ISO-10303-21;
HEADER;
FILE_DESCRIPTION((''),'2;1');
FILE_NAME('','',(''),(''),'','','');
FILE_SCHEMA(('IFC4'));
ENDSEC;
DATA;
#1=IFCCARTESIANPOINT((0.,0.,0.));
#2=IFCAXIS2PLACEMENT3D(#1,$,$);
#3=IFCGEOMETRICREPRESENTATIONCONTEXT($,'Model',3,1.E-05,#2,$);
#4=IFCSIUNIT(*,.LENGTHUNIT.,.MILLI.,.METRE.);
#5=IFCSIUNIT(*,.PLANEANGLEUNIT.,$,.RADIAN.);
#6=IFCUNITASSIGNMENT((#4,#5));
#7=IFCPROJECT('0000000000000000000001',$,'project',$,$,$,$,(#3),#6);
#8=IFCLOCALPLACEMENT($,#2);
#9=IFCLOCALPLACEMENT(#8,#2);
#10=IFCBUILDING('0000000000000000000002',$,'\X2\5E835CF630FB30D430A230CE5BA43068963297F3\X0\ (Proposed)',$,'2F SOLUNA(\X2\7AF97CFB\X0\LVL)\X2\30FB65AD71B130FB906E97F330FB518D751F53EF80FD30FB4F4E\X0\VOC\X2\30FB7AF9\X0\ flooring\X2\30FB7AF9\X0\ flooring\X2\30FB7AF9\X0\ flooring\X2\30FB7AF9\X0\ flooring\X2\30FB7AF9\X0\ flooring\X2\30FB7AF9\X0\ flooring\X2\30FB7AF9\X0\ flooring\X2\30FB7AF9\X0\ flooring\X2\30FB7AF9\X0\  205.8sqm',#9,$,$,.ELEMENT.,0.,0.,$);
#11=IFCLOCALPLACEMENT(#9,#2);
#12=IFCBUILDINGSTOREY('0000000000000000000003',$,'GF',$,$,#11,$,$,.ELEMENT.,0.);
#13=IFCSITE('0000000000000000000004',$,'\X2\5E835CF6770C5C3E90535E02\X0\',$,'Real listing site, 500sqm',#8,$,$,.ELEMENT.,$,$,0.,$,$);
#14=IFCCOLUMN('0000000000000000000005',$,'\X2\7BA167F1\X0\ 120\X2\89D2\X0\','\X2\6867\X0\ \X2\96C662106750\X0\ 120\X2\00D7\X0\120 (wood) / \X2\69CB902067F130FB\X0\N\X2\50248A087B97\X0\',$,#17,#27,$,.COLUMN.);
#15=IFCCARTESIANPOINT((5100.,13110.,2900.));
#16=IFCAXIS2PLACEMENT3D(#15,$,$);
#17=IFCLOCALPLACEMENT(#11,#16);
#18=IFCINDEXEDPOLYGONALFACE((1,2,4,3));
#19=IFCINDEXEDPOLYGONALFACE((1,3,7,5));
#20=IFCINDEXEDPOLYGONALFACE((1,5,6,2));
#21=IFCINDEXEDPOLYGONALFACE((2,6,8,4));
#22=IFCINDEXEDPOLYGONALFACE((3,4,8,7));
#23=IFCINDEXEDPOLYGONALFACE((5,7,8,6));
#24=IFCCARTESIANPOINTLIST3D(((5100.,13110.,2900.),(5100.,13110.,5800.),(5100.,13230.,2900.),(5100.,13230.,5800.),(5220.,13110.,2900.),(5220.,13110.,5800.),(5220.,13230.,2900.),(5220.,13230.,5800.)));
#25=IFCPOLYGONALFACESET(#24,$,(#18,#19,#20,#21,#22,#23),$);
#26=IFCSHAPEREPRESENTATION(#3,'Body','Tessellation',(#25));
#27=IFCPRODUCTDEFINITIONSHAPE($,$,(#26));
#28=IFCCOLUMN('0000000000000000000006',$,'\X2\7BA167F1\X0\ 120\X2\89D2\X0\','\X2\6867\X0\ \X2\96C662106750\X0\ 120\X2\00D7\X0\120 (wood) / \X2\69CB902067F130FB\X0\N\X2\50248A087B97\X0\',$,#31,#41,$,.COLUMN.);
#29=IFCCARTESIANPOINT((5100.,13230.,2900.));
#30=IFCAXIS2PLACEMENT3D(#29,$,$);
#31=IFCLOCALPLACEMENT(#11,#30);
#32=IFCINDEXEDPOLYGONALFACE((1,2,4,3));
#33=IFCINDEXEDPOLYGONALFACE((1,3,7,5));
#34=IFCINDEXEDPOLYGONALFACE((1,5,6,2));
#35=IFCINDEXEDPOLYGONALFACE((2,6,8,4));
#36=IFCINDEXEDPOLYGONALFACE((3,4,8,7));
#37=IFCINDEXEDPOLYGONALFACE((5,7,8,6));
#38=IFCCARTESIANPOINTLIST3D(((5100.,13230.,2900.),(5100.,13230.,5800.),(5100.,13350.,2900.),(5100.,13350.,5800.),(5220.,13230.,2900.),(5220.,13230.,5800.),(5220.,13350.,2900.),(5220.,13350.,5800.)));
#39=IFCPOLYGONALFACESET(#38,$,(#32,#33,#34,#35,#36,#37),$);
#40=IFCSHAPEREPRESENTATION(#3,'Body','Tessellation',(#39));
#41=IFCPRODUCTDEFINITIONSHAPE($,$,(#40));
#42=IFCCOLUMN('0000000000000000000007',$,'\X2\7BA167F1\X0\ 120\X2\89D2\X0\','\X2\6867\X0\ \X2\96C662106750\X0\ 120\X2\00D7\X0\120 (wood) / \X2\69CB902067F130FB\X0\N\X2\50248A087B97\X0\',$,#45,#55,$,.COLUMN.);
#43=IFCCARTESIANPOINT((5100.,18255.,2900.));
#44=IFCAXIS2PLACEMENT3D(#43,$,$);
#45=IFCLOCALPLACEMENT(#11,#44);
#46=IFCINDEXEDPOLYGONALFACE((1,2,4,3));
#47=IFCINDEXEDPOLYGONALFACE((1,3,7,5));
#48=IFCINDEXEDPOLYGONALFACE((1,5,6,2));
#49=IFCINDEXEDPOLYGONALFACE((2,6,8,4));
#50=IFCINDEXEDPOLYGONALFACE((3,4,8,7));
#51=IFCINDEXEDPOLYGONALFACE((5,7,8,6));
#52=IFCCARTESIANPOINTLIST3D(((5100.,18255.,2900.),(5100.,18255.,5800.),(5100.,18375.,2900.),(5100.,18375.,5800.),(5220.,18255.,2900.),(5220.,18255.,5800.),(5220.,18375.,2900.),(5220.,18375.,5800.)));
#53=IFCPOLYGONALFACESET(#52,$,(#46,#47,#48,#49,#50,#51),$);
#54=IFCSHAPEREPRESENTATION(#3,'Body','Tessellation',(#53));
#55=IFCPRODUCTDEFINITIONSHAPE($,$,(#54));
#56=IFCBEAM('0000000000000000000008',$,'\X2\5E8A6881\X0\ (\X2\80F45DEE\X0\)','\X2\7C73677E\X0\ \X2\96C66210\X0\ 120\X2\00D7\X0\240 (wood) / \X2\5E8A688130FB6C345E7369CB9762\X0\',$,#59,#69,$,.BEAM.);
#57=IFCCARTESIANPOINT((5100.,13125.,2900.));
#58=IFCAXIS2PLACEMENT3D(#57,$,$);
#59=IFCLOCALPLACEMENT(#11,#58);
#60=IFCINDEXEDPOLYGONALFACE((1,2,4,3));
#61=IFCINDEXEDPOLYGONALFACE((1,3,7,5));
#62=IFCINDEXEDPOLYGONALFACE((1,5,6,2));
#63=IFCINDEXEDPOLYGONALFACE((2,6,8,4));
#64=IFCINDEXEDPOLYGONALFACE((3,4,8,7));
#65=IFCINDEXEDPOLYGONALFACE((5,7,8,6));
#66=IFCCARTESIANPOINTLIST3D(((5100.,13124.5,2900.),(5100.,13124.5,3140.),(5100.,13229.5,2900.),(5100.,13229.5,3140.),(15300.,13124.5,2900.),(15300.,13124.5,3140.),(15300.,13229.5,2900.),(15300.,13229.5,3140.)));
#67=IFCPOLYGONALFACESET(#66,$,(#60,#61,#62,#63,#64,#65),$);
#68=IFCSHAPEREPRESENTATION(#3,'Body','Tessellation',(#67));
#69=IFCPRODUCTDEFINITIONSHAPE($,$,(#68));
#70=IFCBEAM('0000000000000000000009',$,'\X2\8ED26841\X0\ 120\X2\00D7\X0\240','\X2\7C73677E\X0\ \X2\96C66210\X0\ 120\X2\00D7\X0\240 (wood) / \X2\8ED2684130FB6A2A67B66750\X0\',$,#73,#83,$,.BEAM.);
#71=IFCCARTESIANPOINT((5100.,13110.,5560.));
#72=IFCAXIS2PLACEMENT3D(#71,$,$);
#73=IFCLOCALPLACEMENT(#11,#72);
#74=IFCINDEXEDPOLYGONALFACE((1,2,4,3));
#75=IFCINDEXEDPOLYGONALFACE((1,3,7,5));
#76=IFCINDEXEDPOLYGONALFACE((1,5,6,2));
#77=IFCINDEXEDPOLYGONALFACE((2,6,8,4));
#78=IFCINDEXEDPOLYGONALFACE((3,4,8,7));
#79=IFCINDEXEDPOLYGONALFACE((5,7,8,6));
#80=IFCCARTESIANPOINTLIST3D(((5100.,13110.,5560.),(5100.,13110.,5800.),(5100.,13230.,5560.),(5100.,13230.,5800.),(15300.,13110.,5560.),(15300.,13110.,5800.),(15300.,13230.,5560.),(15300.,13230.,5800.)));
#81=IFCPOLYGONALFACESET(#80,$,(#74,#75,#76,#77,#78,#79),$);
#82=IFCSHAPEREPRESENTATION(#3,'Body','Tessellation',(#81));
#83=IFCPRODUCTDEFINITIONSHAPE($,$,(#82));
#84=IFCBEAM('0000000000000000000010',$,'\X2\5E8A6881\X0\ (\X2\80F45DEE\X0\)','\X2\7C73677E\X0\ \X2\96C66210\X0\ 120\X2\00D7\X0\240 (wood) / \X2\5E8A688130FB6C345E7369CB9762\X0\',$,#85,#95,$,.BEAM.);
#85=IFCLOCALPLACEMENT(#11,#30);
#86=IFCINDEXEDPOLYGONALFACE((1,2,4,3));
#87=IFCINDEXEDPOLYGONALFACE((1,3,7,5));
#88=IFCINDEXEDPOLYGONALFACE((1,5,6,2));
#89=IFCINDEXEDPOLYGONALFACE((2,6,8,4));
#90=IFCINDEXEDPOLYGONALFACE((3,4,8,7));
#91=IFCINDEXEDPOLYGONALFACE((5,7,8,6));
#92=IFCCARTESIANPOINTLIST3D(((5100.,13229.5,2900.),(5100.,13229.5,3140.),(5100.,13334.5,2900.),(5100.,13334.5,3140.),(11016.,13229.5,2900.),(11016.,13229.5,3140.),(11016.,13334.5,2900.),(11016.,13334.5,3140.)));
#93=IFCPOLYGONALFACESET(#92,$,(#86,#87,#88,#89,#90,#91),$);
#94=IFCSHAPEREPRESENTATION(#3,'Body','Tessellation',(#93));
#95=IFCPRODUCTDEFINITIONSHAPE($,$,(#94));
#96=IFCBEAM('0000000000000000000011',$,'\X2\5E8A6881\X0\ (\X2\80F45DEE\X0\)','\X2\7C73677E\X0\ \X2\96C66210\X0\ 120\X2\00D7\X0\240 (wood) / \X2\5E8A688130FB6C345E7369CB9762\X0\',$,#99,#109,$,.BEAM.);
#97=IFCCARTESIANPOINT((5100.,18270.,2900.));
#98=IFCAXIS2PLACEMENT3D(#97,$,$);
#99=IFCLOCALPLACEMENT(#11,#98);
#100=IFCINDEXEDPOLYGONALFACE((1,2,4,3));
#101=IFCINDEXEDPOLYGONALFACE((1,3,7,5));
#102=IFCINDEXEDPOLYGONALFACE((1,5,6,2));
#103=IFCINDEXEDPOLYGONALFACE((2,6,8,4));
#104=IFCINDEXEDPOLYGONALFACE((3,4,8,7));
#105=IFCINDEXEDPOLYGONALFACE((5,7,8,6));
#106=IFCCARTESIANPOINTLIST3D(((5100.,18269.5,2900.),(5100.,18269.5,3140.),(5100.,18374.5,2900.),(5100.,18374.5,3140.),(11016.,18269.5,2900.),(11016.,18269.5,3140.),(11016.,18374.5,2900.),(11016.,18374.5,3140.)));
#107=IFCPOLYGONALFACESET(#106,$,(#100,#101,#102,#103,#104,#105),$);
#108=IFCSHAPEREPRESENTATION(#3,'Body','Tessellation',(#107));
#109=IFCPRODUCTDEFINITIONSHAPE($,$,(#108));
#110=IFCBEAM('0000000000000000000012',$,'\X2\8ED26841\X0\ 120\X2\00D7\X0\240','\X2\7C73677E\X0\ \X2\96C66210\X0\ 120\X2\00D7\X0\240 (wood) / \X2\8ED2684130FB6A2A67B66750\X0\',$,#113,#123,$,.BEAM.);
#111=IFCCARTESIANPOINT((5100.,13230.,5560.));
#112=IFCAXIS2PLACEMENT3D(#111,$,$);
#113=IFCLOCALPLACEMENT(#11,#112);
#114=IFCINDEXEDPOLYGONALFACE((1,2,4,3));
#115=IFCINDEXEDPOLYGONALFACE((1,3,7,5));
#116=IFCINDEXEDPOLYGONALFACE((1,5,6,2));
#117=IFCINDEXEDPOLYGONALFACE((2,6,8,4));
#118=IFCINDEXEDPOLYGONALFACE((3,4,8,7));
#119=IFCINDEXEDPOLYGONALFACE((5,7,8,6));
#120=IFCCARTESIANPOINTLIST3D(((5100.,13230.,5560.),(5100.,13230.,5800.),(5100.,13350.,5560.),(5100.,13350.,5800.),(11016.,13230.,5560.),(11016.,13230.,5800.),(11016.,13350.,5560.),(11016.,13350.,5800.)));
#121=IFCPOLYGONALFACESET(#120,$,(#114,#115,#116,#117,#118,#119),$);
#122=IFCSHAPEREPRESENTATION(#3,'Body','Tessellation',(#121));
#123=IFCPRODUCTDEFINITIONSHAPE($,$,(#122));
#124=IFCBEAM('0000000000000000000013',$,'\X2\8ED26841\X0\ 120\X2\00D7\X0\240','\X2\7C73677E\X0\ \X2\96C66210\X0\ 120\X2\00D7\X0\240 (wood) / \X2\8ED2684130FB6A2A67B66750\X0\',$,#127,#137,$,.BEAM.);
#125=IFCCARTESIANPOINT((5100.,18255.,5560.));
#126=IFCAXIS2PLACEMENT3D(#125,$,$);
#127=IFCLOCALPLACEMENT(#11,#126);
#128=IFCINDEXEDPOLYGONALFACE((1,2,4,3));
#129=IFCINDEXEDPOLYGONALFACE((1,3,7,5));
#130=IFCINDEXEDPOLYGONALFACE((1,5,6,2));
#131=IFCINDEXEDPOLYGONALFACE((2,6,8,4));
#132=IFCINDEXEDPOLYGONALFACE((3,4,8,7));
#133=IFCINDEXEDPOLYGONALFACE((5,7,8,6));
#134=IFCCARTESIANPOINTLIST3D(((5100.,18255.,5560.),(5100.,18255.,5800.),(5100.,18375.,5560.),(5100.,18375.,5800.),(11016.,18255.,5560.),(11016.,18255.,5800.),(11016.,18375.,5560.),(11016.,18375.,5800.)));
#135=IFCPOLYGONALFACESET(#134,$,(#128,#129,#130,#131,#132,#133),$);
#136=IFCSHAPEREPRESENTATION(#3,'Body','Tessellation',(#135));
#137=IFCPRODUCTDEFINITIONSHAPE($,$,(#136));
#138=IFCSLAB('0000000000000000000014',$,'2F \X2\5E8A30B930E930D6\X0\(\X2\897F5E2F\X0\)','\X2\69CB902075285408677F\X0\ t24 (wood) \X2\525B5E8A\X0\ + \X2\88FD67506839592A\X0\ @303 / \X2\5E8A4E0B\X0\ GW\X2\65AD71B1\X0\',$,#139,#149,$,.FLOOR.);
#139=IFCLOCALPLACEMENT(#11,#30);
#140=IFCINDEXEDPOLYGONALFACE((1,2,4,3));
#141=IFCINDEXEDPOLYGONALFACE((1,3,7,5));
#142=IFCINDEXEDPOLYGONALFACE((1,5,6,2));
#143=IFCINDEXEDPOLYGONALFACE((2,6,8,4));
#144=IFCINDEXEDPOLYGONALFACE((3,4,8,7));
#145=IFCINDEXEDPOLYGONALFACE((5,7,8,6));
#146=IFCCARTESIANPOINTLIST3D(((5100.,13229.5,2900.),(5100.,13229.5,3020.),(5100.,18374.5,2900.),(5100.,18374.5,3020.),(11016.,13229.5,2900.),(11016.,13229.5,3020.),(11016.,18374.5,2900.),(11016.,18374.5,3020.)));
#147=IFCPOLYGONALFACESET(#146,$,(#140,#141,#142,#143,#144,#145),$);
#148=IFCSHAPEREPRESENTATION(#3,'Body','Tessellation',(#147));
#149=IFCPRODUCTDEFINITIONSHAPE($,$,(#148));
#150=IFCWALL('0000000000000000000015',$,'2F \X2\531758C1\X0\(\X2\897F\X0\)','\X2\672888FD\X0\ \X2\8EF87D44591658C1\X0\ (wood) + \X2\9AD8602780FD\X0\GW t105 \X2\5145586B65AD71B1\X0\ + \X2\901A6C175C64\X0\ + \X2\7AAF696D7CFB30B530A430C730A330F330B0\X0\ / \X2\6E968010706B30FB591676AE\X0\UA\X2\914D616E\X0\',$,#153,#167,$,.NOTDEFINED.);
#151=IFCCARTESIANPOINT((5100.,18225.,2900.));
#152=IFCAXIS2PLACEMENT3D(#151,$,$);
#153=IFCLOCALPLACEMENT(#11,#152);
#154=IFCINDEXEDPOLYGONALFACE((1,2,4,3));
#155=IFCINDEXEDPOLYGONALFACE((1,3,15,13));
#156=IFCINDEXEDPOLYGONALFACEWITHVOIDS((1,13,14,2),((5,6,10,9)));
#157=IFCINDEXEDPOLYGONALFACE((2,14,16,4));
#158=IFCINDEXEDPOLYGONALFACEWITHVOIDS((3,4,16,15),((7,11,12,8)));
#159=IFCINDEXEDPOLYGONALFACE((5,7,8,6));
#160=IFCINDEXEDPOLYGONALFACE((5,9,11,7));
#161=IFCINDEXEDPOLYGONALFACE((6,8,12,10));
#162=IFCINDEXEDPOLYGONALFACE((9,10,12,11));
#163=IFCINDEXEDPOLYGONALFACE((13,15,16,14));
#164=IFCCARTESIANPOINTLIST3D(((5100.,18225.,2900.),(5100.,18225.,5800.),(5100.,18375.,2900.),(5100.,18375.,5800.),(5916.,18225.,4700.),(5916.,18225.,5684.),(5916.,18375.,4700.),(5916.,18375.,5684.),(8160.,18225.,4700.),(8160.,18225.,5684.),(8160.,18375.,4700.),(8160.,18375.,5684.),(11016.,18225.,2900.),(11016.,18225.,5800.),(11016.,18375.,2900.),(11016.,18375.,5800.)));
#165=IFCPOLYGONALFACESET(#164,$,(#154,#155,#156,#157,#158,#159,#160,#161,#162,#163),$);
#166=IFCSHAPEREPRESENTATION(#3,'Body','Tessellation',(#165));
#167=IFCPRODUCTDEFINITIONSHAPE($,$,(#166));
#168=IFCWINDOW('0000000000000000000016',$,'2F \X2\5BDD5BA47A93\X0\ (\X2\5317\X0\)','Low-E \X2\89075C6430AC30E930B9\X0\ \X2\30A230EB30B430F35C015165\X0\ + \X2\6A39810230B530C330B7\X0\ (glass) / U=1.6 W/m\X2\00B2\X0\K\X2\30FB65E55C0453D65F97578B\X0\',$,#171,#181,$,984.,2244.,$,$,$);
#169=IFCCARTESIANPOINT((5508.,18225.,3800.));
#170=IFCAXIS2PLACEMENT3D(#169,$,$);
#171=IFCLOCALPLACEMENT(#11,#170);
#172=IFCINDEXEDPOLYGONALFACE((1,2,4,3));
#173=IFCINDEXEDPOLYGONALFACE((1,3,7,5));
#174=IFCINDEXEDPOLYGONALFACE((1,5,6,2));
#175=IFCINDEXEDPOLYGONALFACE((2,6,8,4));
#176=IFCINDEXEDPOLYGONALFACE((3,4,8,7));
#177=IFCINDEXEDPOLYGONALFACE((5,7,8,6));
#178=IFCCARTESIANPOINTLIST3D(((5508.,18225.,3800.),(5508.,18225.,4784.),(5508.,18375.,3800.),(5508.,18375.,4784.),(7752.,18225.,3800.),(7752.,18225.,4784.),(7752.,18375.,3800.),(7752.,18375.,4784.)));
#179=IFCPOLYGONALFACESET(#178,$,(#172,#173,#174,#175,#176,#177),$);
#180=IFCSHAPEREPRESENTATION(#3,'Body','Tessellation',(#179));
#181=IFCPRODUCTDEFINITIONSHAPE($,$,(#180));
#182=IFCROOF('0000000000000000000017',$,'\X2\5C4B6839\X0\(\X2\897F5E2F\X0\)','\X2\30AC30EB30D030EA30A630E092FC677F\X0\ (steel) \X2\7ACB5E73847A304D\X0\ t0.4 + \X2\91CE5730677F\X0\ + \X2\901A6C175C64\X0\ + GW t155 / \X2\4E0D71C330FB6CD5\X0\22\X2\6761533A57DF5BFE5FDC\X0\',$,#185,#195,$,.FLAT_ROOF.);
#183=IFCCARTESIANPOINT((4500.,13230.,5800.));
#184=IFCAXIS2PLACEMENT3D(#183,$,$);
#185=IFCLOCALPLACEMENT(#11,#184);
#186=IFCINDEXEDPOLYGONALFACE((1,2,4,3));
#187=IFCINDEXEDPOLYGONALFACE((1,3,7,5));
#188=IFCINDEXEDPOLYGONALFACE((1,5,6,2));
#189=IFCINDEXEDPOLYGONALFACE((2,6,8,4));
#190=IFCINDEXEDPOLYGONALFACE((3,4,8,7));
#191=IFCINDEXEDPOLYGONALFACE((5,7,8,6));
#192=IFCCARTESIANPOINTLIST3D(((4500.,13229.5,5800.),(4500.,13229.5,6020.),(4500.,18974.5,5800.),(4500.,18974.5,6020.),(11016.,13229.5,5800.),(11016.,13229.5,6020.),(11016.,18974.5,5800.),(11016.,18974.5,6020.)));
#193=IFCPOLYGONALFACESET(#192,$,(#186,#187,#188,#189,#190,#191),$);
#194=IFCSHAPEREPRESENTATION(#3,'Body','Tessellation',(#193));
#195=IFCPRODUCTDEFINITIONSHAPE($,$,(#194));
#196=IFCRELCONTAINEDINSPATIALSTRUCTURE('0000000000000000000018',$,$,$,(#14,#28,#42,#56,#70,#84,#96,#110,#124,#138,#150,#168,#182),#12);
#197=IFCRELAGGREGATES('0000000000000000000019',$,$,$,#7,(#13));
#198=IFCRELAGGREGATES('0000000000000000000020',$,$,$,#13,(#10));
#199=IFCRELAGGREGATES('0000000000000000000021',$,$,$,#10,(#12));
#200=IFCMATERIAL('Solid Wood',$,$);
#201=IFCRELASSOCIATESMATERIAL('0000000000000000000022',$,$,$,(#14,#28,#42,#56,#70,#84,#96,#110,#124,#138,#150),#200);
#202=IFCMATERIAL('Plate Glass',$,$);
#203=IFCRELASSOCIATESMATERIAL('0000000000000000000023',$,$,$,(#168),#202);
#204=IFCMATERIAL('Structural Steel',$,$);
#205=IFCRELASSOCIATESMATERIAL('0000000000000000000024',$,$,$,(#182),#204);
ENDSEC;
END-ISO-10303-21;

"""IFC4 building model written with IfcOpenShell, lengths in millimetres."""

from ifc_helpers import new_model, si_unit, frame, frame_2d, origin, place, context, project, spatial, rectangle, extrude, material, element, fill, save


model = new_model("IFC4")

# Units and contexts
model_context = context("Model", 3, precision=1e-05, world=origin())
ifc_project = project(units=[si_unit("LENGTHUNIT", "METRE", prefix="MILLI"), si_unit("PLANEANGLEUNIT", "RADIAN")], contexts=[model_context])

# Site, building, storey
site_placement = place(None, origin())
site = spatial("IfcSite", under=ifc_project, at=site_placement, Name="広島県尾道市", ObjectType="Real listing site, 500sqm", CompositionType="ELEMENT", RefElevation=0.0)
building_placement = place(site_placement, origin())
building = spatial("IfcBuilding", under=site, at=building_placement, Name="広島・ピアノ室と防音 (Proposed)", ObjectType="2F SOLUNA(竹系LVL)・断熱・遮音・再生可能・低VOC・竹 flooring・竹 flooring・竹 flooring・竹 flooring・竹 flooring・竹 flooring・竹 flooring・竹 flooring・竹  205.8sqm", CompositionType="ELEMENT", ElevationOfRefHeight=0.0, ElevationOfTerrain=0.0)
storey_placement = place(building_placement, origin())
storey = spatial("IfcBuildingStorey", under=building, at=storey_placement, Name="GF", CompositionType="ELEMENT", Elevation=0.0)

# Columns
ifc_material_1 = material(Name="Solid Wood")
column_1_placement = place(storey_placement, frame((5100.0, 13110.0, 2900.0)))
element("IfcColumn", 1, at=column_1_placement, inside=storey, material=ifc_material_1, Name="管柱 120角", Description="桧 集成材 120×120 (wood) / 構造柱・N値計算", PredefinedType="COLUMN", context=model_context, shape_type="SweptSolid", body=[
    extrude(rectangle(XDim=120.0, YDim=120.0, at=frame_2d((60.0, 60.0))), frame((5100.0, 13110.0, 2900.0)), (0.0, 0.0, 1.0), 2900.0),
])
column_2_placement = place(storey_placement, frame((5100.0, 13230.0, 2900.0)))
element("IfcColumn", 2, at=column_2_placement, inside=storey, material=ifc_material_1, Name="管柱 120角", Description="桧 集成材 120×120 (wood) / 構造柱・N値計算", PredefinedType="COLUMN", context=model_context, shape_type="SweptSolid", body=[
    extrude(rectangle(XDim=120.0, YDim=120.0, at=frame_2d((60.0, 60.0))), frame((5100.0, 13230.0, 2900.0)), (0.0, 0.0, 1.0), 2900.0),
])
column_3_placement = place(storey_placement, frame((5100.0, 18255.0, 2900.0)))
element("IfcColumn", 3, at=column_3_placement, inside=storey, material=ifc_material_1, Name="管柱 120角", Description="桧 集成材 120×120 (wood) / 構造柱・N値計算", PredefinedType="COLUMN", context=model_context, shape_type="SweptSolid", body=[
    extrude(rectangle(XDim=120.0, YDim=120.0, at=frame_2d((60.0, 60.0))), frame((5100.0, 18255.0, 2900.0)), (0.0, 0.0, 1.0), 2900.0),
])

# Beams
beam_1_placement = place(storey_placement, frame((5100.0, 13125.0, 2900.0)))
element("IfcBeam", 4, at=beam_1_placement, inside=storey, material=ifc_material_1, Name="床梁 (胴差)", Description="米松 集成 120×240 (wood) / 床梁・水平構面", PredefinedType="BEAM", context=model_context, shape_type="SweptSolid", body=[
    extrude(rectangle(XDim=10200.0, YDim=105.0, at=frame_2d((5100.0, 52.0))), frame((5100.0, 13125.0, 2900.0)), (0.0, 0.0, 1.0), 240.0),
])
beam_2_placement = place(storey_placement, frame((5100.0, 13110.0, 5560.0)))
element("IfcBeam", 5, at=beam_2_placement, inside=storey, material=ifc_material_1, Name="軒桁 120×240", Description="米松 集成 120×240 (wood) / 軒桁・横架材", PredefinedType="BEAM", context=model_context, shape_type="SweptSolid", body=[
    extrude(rectangle(XDim=10200.0, YDim=120.0, at=frame_2d((5100.0, 60.0))), frame((5100.0, 13110.0, 5560.0)), (0.0, 0.0, 1.0), 240.0),
])
beam_3_placement = place(storey_placement, frame((5100.0, 13230.0, 2900.0)))
element("IfcBeam", 6, at=beam_3_placement, inside=storey, material=ifc_material_1, Name="床梁 (胴差)", Description="米松 集成 120×240 (wood) / 床梁・水平構面", PredefinedType="BEAM", context=model_context, shape_type="SweptSolid", body=[
    extrude(rectangle(XDim=5916.0, YDim=105.0, at=frame_2d((2958.0, 52.0))), frame((5100.0, 13230.0, 2900.0)), (0.0, 0.0, 1.0), 240.0),
])
beam_4_placement = place(storey_placement, frame((5100.0, 18270.0, 2900.0)))
element("IfcBeam", 7, at=beam_4_placement, inside=storey, material=ifc_material_1, Name="床梁 (胴差)", Description="米松 集成 120×240 (wood) / 床梁・水平構面", PredefinedType="BEAM", context=model_context, shape_type="SweptSolid", body=[
    extrude(rectangle(XDim=5916.0, YDim=105.0, at=frame_2d((2958.0, 52.0))), frame((5100.0, 18270.0, 2900.0)), (0.0, 0.0, 1.0), 240.0),
])
beam_5_placement = place(storey_placement, frame((5100.0, 13230.0, 5560.0)))
element("IfcBeam", 8, at=beam_5_placement, inside=storey, material=ifc_material_1, Name="軒桁 120×240", Description="米松 集成 120×240 (wood) / 軒桁・横架材", PredefinedType="BEAM", context=model_context, shape_type="SweptSolid", body=[
    extrude(rectangle(XDim=5916.0, YDim=120.0, at=frame_2d((2958.0, 60.0))), frame((5100.0, 13230.0, 5560.0)), (0.0, 0.0, 1.0), 240.0),
])
beam_6_placement = place(storey_placement, frame((5100.0, 18255.0, 5560.0)))
element("IfcBeam", 9, at=beam_6_placement, inside=storey, material=ifc_material_1, Name="軒桁 120×240", Description="米松 集成 120×240 (wood) / 軒桁・横架材", PredefinedType="BEAM", context=model_context, shape_type="SweptSolid", body=[
    extrude(rectangle(XDim=5916.0, YDim=120.0, at=frame_2d((2958.0, 60.0))), frame((5100.0, 18255.0, 5560.0)), (0.0, 0.0, 1.0), 240.0),
])

# Slab
slab_placement = place(storey_placement, frame((5100.0, 13230.0, 2900.0)))
element("IfcSlab", 10, at=slab_placement, inside=storey, material=ifc_material_1, Name="2F 床スラブ(西帯)", Description="構造用合板 t24 (wood) 剛床 + 製材根太 @303 / 床下 GW断熱", PredefinedType="FLOOR", context=model_context, shape_type="SweptSolid", body=[
    extrude(rectangle(XDim=5916.0, YDim=5145.0, at=frame_2d((2958.0, 2572.0))), frame((5100.0, 13230.0, 2900.0)), (0.0, 0.0, 1.0), 120.0),
])

# Wall, opening, window
wall_1_placement = place(storey_placement, frame((5100.0, 18225.0, 2900.0)))
wall_1 = element("IfcWall", 11, at=wall_1_placement, inside=storey, material=ifc_material_1, Name="2F 北壁(西)", Description="木製 軸組外壁 (wood) + 高性能GW t105 充填断熱 + 通気層 + 窯業系サイディング / 準耐火・外皮UA配慮", PredefinedType="NOTDEFINED", context=model_context, shape_type="SweptSolid", body=[
    extrude(rectangle(XDim=5916.0, YDim=150.0, at=frame_2d((2958.0, 75.0))), frame((5100.0, 18225.0, 2900.0)), (0.0, 0.0, 1.0), 2900.0),
])
opening_placement = place(storey_placement, frame((5508.0, 18225.0, 3800.0)))
opening = element("IfcOpeningElement", 12, at=opening_placement, cuts=wall_1, PredefinedType="NOTDEFINED", context=model_context, shape_type="SweptSolid", body=[
    extrude(rectangle(XDim=2244.0, YDim=150.0, at=frame_2d((1122.0, 75.0))), frame((5508.0, 18225.0, 3800.0)), (0.0, 0.0, 1.0), 984.0),
])
ifc_material_2 = material(Name="Plate Glass")
window_placement = place(storey_placement, frame((5508.0, 18225.0, 3800.0)))
window = element("IfcWindow", 13, at=window_placement, inside=storey, material=ifc_material_2, Name="2F 寝室窓 (北)", Description="Low-E 複層ガラス アルゴン封入 + 樹脂サッシ (glass) / U=1.6 W/m²K・日射取得型", OverallHeight=984.0, OverallWidth=2244.0, context=model_context, shape_type="SweptSolid", body=[
    extrude(rectangle(XDim=2244.0, YDim=150.0, at=frame_2d((1122.0, 75.0))), frame((5508.0, 18225.0, 3800.0)), (0.0, 0.0, 1.0), 984.0),
])
fill(opening, window)

# Roof
ifc_material_3 = material(Name="Structural Steel")
for number, where, name in (
    (14, (4500.0, 13230.0, 5800.0), "屋根(西帯)"),
):
    element("IfcRoof", number, at=place(storey_placement, frame(where)), inside=storey, material=ifc_material_3, Name=name, Description="ガルバリウム鋼板 (steel) 立平葺き t0.4 + 野地板 + 通気層 + GW t155 / 不燃・法22条区域対応", PredefinedType="FLAT_ROOF", context=model_context, shape_type="SweptSolid", body=[
        extrude(rectangle(XDim=6516.0, YDim=5745.0, at=frame_2d((3258.0, 2872.0))), frame((4500.0, 13230.0, 5800.0)), (0.0, 0.0, 1.0), 220.0),
    ])

save(model, "model.ifc")
